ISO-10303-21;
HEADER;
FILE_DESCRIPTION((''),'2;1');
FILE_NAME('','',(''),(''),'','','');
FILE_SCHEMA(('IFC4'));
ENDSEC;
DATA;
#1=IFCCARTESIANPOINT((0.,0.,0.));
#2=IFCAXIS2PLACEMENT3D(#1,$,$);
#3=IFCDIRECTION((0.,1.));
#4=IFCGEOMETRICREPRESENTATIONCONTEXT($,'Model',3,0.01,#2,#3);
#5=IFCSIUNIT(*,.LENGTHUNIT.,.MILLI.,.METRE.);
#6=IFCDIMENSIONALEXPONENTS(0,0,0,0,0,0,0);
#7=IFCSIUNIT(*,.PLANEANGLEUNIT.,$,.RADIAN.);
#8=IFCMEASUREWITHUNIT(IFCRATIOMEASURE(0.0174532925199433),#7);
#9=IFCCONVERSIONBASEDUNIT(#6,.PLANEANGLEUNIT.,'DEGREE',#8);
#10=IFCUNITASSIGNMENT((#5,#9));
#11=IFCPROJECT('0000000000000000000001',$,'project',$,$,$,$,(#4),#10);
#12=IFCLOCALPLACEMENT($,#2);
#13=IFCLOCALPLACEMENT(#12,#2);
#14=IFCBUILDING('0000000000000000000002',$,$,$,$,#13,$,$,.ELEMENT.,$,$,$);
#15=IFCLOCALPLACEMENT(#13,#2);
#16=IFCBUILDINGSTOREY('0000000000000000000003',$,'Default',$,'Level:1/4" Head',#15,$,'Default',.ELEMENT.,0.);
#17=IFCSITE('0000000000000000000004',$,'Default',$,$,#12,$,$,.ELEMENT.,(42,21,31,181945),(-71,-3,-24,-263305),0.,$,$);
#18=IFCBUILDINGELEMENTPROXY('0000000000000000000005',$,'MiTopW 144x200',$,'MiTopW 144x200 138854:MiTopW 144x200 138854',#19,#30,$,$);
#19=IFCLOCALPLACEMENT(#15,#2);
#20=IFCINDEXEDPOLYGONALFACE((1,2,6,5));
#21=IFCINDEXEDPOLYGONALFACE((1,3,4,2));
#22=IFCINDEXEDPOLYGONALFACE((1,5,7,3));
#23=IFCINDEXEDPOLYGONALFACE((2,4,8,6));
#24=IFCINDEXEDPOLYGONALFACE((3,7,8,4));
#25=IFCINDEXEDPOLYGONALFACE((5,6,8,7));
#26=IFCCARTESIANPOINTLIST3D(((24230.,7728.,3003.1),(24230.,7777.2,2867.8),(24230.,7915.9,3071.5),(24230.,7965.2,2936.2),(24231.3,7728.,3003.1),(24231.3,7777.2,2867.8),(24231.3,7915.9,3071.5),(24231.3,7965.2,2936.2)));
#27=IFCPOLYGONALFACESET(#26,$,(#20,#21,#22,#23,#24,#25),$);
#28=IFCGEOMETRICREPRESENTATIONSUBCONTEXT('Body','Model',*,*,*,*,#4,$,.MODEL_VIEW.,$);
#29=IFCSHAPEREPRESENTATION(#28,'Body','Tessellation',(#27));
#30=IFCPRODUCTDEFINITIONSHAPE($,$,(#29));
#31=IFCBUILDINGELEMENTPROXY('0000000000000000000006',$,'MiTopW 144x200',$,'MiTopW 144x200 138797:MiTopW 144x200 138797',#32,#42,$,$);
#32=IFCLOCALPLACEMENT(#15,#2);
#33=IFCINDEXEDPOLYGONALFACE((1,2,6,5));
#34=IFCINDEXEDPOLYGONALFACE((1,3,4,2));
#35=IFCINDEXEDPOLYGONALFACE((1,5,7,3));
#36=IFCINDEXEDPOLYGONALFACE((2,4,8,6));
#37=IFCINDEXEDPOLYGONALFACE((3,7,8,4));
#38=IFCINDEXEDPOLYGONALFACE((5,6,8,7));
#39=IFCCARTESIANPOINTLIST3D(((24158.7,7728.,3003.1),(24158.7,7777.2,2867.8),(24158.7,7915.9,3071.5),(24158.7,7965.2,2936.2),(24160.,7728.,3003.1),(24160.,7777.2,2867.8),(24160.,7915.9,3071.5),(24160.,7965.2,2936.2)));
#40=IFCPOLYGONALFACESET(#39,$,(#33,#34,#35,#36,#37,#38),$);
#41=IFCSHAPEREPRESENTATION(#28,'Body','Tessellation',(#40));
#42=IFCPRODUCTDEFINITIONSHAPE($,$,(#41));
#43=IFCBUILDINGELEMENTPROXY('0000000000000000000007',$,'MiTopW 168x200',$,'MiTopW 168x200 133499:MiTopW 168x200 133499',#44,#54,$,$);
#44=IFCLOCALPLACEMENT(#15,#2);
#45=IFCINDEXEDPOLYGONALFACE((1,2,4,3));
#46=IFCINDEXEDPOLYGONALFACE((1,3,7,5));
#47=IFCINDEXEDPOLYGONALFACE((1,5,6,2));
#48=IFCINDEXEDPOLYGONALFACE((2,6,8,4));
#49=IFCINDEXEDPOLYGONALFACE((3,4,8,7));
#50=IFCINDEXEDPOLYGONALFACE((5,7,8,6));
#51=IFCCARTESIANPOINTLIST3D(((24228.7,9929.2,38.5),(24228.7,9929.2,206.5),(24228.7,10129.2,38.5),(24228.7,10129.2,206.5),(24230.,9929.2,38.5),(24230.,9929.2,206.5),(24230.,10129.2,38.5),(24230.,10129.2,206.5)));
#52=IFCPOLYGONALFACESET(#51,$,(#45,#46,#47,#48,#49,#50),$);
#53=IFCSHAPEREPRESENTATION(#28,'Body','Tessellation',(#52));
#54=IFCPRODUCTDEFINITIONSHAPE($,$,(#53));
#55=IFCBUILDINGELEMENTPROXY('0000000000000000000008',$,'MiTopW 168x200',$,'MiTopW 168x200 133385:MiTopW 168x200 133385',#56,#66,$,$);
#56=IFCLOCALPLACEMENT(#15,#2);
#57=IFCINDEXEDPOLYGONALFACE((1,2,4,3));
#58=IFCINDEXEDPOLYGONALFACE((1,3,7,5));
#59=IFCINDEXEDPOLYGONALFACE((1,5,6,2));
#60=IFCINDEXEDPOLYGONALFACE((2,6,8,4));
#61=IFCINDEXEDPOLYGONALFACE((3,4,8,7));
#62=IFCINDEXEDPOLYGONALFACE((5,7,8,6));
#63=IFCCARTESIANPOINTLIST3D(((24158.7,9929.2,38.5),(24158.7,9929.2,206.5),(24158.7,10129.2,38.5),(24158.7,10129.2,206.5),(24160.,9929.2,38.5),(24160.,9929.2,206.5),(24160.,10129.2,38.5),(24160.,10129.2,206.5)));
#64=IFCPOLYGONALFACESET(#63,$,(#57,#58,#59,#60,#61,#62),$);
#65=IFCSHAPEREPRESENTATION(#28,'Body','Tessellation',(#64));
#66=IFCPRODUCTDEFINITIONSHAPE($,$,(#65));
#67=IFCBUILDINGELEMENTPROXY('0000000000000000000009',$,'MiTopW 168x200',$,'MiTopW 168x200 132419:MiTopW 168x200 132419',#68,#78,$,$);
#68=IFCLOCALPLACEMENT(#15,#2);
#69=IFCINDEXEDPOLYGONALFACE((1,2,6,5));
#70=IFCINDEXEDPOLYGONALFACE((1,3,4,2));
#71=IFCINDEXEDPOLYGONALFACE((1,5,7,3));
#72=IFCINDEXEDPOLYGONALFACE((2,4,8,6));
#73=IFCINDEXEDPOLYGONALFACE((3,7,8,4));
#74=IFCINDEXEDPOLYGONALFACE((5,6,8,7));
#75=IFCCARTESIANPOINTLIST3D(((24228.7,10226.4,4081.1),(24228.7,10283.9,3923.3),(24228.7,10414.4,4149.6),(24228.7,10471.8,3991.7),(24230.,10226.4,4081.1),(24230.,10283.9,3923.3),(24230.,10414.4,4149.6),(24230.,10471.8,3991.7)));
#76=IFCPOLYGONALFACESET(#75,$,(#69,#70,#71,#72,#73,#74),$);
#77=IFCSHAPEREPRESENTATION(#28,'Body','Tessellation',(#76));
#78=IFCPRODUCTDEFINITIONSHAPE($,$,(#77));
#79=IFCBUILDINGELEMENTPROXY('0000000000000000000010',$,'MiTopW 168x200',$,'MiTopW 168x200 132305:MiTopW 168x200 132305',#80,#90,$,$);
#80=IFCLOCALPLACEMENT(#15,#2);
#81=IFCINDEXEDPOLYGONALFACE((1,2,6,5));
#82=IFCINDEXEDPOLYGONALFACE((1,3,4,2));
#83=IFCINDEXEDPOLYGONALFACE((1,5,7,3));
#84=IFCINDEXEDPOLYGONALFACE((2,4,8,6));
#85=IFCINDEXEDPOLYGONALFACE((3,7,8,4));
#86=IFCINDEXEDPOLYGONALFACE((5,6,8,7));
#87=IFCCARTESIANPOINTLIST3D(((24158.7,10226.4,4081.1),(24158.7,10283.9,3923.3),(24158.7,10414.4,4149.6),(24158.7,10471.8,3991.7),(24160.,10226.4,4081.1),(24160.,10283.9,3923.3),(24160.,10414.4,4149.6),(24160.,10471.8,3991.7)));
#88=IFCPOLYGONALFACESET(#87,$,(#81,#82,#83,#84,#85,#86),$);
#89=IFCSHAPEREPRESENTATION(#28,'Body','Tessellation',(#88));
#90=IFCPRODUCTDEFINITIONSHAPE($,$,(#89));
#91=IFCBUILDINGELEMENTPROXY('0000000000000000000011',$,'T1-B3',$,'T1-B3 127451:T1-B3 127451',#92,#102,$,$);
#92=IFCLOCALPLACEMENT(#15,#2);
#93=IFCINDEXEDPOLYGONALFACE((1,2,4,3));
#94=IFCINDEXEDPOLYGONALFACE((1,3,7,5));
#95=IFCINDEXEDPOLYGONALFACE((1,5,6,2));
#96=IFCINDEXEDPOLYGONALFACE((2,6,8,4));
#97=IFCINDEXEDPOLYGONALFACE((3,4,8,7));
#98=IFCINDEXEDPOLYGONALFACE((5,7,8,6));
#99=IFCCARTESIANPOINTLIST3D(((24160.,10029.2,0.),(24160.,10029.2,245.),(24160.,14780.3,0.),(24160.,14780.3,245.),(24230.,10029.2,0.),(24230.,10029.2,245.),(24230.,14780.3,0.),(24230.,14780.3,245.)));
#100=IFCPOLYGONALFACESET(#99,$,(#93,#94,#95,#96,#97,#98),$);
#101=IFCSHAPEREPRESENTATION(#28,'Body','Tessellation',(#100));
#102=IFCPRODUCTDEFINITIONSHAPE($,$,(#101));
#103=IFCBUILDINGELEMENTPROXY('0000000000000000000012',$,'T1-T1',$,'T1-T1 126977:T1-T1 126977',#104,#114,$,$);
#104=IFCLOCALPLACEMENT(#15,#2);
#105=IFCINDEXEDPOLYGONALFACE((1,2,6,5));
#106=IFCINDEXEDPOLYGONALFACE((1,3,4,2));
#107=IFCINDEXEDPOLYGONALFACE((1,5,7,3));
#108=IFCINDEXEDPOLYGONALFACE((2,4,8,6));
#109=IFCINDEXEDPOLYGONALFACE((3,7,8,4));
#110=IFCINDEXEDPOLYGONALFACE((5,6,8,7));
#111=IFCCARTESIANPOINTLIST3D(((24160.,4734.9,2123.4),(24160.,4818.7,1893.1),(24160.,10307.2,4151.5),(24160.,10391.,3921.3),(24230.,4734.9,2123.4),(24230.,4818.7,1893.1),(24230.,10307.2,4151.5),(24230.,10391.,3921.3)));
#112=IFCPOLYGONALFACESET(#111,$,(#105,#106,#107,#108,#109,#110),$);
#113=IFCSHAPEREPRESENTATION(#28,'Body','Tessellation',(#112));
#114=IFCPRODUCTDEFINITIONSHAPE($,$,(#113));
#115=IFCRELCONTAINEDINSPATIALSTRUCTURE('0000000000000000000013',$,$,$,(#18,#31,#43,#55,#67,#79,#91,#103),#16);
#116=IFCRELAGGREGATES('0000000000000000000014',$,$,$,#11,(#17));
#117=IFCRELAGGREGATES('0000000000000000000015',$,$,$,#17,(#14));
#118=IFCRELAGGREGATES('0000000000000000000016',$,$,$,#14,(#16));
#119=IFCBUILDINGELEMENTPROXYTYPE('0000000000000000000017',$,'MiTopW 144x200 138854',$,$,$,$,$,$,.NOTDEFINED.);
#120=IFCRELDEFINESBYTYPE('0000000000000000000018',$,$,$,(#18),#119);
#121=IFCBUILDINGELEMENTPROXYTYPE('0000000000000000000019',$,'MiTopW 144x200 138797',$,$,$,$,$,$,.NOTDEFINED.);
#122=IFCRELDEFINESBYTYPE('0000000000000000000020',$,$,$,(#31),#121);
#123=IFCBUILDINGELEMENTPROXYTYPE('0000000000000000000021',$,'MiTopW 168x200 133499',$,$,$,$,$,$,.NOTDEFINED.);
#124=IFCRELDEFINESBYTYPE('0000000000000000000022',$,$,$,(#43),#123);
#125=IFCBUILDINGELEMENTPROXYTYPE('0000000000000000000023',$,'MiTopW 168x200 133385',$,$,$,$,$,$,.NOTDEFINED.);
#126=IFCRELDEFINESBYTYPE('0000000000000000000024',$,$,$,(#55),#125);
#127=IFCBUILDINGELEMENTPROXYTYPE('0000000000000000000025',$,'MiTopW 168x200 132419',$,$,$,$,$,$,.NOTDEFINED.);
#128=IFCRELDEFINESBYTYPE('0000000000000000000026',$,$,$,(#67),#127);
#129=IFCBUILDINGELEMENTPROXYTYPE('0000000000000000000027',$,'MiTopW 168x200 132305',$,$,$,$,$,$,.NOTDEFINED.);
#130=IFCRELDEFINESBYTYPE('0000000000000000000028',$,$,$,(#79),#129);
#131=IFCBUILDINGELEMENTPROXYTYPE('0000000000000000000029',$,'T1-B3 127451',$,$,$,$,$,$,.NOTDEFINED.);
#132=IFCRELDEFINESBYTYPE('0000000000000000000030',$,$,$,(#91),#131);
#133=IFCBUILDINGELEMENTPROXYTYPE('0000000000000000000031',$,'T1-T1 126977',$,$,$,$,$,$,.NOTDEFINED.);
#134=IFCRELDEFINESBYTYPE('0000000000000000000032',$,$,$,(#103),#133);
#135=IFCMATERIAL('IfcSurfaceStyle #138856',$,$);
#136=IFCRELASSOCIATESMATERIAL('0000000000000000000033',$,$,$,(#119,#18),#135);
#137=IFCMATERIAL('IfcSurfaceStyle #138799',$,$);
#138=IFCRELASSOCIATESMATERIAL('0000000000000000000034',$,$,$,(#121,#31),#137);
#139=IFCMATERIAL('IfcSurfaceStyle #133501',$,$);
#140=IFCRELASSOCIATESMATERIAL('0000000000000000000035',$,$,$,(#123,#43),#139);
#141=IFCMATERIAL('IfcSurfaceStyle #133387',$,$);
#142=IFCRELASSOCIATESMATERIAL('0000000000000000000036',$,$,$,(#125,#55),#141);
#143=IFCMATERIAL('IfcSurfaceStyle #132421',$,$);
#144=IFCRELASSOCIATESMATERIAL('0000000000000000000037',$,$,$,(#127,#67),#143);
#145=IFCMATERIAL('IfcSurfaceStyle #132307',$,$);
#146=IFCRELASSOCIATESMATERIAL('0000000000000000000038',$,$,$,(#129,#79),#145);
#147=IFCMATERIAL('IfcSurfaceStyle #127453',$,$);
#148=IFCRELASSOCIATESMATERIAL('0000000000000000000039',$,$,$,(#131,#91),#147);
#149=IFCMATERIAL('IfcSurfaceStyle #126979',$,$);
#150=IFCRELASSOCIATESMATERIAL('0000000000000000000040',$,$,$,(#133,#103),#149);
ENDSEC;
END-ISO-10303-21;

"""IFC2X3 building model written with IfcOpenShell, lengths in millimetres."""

from ifc_helpers import new_model, entity, si_unit, converted_unit, direction, frame, origin, origin_2d_with_axis, place, context, subcontext, project, spatial, polyline, rectangle, outline, extrude, source, transform, mapped, material, type_object, type_shapes, element, save


model = new_model("IFC2X3")

# Units and contexts
model_context = context("Model", 3, precision=0.01, world=origin(), true_north=direction((0.0, 1.0)))
body_context = subcontext(model_context, "Body", "Model", "MODEL_VIEW")
ifc_project = project(units=[si_unit("LENGTHUNIT", "METRE", prefix="MILLI"), converted_unit("PLANEANGLEUNIT", "DEGREE", entity("IfcRatioMeasure", 0.0174532925199433), si_unit("PLANEANGLEUNIT", "RADIAN"), dimensions=[0, 0, 0, 0, 0, 0, 0])], contexts=[model_context])

# Site, building, storey
site_placement = place(None, origin())
site = spatial("IfcSite", under=ifc_project, at=site_placement, Name="Default", CompositionType="ELEMENT", RefLatitude=(42, 21, 31, 181945), RefLongitude=(-71, -3, -24, -263305), RefElevation=0.0)
building_placement = place(site_placement, origin())
building = spatial("IfcBuilding", under=site, at=building_placement, CompositionType="ELEMENT")
storey_placement = place(building_placement, origin())
storey = spatial("IfcBuildingStorey", under=building, at=storey_placement, Name="Default", ObjectType="Level:1/4\" Head", LongName="Default", CompositionType="ELEMENT", Elevation=0.0)

# Building element proxies
ifc_material_1 = material(Name="IfcSurfaceStyle #138856")
building_element_proxy_type_1 = type_object("IfcBuildingElementProxyType", Name="MiTopW 144x200 138854", PredefinedType="NOTDEFINED", material=ifc_material_1)
shared_shape_1 = source(origin(), body_context, "Body", "SweptSolid", [
    extrude(outline(polyline([(-100.0, -72.0), (100.0, -72.0), (100.0, 72.0), (-100.0, 72.0), (-100.0, -72.0)])), frame((100.0, 72.0, 0.0), z_axis=(0.0, 0.0, 1.0), x_axis=(-1.0, 0.0, 0.0)), (0.0, 0.0, 1.0), 1.3),
])
type_shapes(building_element_proxy_type_1, [shared_shape_1])
proxy_1_placement = place(building_placement, frame((24231.3, 7965.2, 2936.2), z_axis=(-1.0, 0.0, 0.0), x_axis=(0.0, -0.939693, -0.34202)))
element("IfcBuildingElementProxy", 1, at=proxy_1_placement, inside=storey, type_object=building_element_proxy_type_1, material=ifc_material_1, Name="MiTopW 144x200", ObjectType="MiTopW 144x200 138854:MiTopW 144x200 138854", context=body_context, shape_type="MappedRepresentation", body=[
    mapped(shared_shape_1, transform((0.0, 0.0, 0.0), scale=1.0)),
])
ifc_material_2 = material(Name="IfcSurfaceStyle #138799")
building_element_proxy_type_2 = type_object("IfcBuildingElementProxyType", Name="MiTopW 144x200 138797", PredefinedType="NOTDEFINED", material=ifc_material_2)
shared_shape_2 = source(origin(), body_context, "Body", "SweptSolid", [
    extrude(outline(polyline([(-100.0, -72.0), (100.0, -72.0), (100.0, 72.0), (-100.0, 72.0), (-100.0, -72.0)])), frame((100.0, 72.0, 0.0), z_axis=(0.0, 0.0, 1.0), x_axis=(-1.0, 0.0, 0.0)), (0.0, 0.0, 1.0), 1.3),
])
type_shapes(building_element_proxy_type_2, [shared_shape_2])
proxy_2_placement = place(building_placement, frame((24160.0, 7965.2, 2936.2), z_axis=(-1.0, 0.0, 0.0), x_axis=(0.0, -0.939693, -0.34202)))
element("IfcBuildingElementProxy", 2, at=proxy_2_placement, inside=storey, type_object=building_element_proxy_type_2, material=ifc_material_2, Name="MiTopW 144x200", ObjectType="MiTopW 144x200 138797:MiTopW 144x200 138797", context=body_context, shape_type="MappedRepresentation", body=[
    mapped(shared_shape_2, transform((0.0, 0.0, 0.0), scale=1.0)),
])
ifc_material_3 = material(Name="IfcSurfaceStyle #133501")
building_element_proxy_type_3 = type_object("IfcBuildingElementProxyType", Name="MiTopW 168x200 133499", PredefinedType="NOTDEFINED", material=ifc_material_3)
shared_shape_3 = source(origin(), body_context, "Body", "SweptSolid", [
    extrude(rectangle(XDim=200.0, YDim=168.0, at=origin_2d_with_axis()), frame((100.0, 84.0, 0.0), z_axis=(0.0, 0.0, 1.0), x_axis=(-1.0, 0.0, 0.0)), (0.0, 0.0, 1.0), 1.3),
])
type_shapes(building_element_proxy_type_3, [shared_shape_3])
proxy_3_placement = place(building_placement, frame((24230.0, 9929.2, 206.5), z_axis=(-1.0, 0.0, 0.0), x_axis=(0.0, 1.0, 0.0)))
element("IfcBuildingElementProxy", 3, at=proxy_3_placement, inside=storey, type_object=building_element_proxy_type_3, material=ifc_material_3, Name="MiTopW 168x200", ObjectType="MiTopW 168x200 133499:MiTopW 168x200 133499", context=body_context, shape_type="MappedRepresentation", body=[
    mapped(shared_shape_3, transform((0.0, 0.0, 0.0), scale=1.0)),
])
ifc_material_4 = material(Name="IfcSurfaceStyle #133387")
building_element_proxy_type_4 = type_object("IfcBuildingElementProxyType", Name="MiTopW 168x200 133385", PredefinedType="NOTDEFINED", material=ifc_material_4)
shared_shape_4 = source(origin(), body_context, "Body", "SweptSolid", [
    extrude(rectangle(XDim=200.0, YDim=168.0, at=origin_2d_with_axis()), frame((100.0, 84.0, 0.0), z_axis=(0.0, 0.0, 1.0), x_axis=(-1.0, 0.0, 0.0)), (0.0, 0.0, 1.0), 1.3),
])
type_shapes(building_element_proxy_type_4, [shared_shape_4])
proxy_4_placement = place(building_placement, frame((24160.0, 9929.2, 206.5), z_axis=(-1.0, 0.0, 0.0), x_axis=(0.0, 1.0, 0.0)))
element("IfcBuildingElementProxy", 4, at=proxy_4_placement, inside=storey, type_object=building_element_proxy_type_4, material=ifc_material_4, Name="MiTopW 168x200", ObjectType="MiTopW 168x200 133385:MiTopW 168x200 133385", context=body_context, shape_type="MappedRepresentation", body=[
    mapped(shared_shape_4, transform((0.0, 0.0, 0.0), scale=1.0)),
])
ifc_material_5 = material(Name="IfcSurfaceStyle #132421")
building_element_proxy_type_5 = type_object("IfcBuildingElementProxyType", Name="MiTopW 168x200 132419", PredefinedType="NOTDEFINED", material=ifc_material_5)
shared_shape_5 = source(origin(), body_context, "Body", "SweptSolid", [
    extrude(outline(polyline([(-100.0, -84.0), (100.0, -84.0), (100.0, 84.0), (-100.0, 84.0), (-100.0, -84.0)])), frame((100.0, 84.0, 0.0), z_axis=(0.0, 0.0, 1.0), x_axis=(-1.0, 0.0, 0.0)), (0.0, 0.0, 1.0), 1.3),
])
type_shapes(building_element_proxy_type_5, [shared_shape_5])
proxy_5_placement = place(building_placement, frame((24230.0, 10226.4, 4081.1), z_axis=(-1.0, 0.0, 0.0), x_axis=(0.0, 0.939693, 0.34202)))
element("IfcBuildingElementProxy", 5, at=proxy_5_placement, inside=storey, type_object=building_element_proxy_type_5, material=ifc_material_5, Name="MiTopW 168x200", ObjectType="MiTopW 168x200 132419:MiTopW 168x200 132419", context=body_context, shape_type="MappedRepresentation", body=[
    mapped(shared_shape_5, transform((0.0, 0.0, 0.0), scale=1.0)),
])
ifc_material_6 = material(Name="IfcSurfaceStyle #132307")
building_element_proxy_type_6 = type_object("IfcBuildingElementProxyType", Name="MiTopW 168x200 132305", PredefinedType="NOTDEFINED", material=ifc_material_6)
shared_shape_6 = source(origin(), body_context, "Body", "SweptSolid", [
    extrude(outline(polyline([(-100.0, -84.0), (100.0, -84.0), (100.0, 84.0), (-100.0, 84.0), (-100.0, -84.0)])), frame((100.0, 84.0, 0.0), z_axis=(0.0, 0.0, 1.0), x_axis=(-1.0, 0.0, 0.0)), (0.0, 0.0, 1.0), 1.3),
])
type_shapes(building_element_proxy_type_6, [shared_shape_6])
proxy_6_placement = place(building_placement, frame((24160.0, 10226.4, 4081.1), z_axis=(-1.0, 0.0, 0.0), x_axis=(0.0, 0.939693, 0.34202)))
element("IfcBuildingElementProxy", 6, at=proxy_6_placement, inside=storey, type_object=building_element_proxy_type_6, material=ifc_material_6, Name="MiTopW 168x200", ObjectType="MiTopW 168x200 132305:MiTopW 168x200 132305", context=body_context, shape_type="MappedRepresentation", body=[
    mapped(shared_shape_6, transform((0.0, 0.0, 0.0), scale=1.0)),
])
ifc_material_7 = material(Name="IfcSurfaceStyle #127453")
building_element_proxy_type_7 = type_object("IfcBuildingElementProxyType", Name="T1-B3 127451", PredefinedType="NOTDEFINED", material=ifc_material_7)
shared_shape_7 = source(origin(), body_context, "Body", "SweptSolid", [
    extrude(rectangle(XDim=4751.0, YDim=245.0, at=origin_2d_with_axis()), frame((2375.5, 122.5, 0.0), z_axis=(0.0, 0.0, 1.0), x_axis=(-1.0, 0.0, 0.0)), (0.0, 0.0, 1.0), 70.0),
])
type_shapes(building_element_proxy_type_7, [shared_shape_7])
proxy_7_placement = place(building_placement, frame((24230.0, 10029.2, 245.0), z_axis=(-1.0, 0.0, 0.0), x_axis=(0.0, 1.0, 0.0)))
element("IfcBuildingElementProxy", 7, at=proxy_7_placement, inside=storey, type_object=building_element_proxy_type_7, material=ifc_material_7, Name="T1-B3", ObjectType="T1-B3 127451:T1-B3 127451", context=body_context, shape_type="MappedRepresentation", body=[
    mapped(shared_shape_7, transform((0.0, 0.0, 0.0), scale=1.0)),
])
ifc_material_8 = material(Name="IfcSurfaceStyle #126979")
building_element_proxy_type_8 = type_object("IfcBuildingElementProxyType", Name="T1-T1 126977", PredefinedType="NOTDEFINED", material=ifc_material_8)
shared_shape_8 = source(origin(), body_context, "Body", "SweptSolid", [
    extrude(outline(polyline([(-2965.0, -122.5), (2965.0, -122.5), (2965.0, 122.5), (-2965.0, 122.5), (-2965.0, -122.5)])), frame((2965.0, 122.5, 0.0), z_axis=(0.0, 0.0, 1.0), x_axis=(-1.0, 0.0, 0.0)), (0.0, 0.0, 1.0), 70.0),
])
type_shapes(building_element_proxy_type_8, [shared_shape_8])
proxy_8_placement = place(building_placement, frame((24230.0, 10391.0, 3921.3), z_axis=(-1.0, 0.0, 0.0), x_axis=(0.0, -0.939693, -0.34202)))
element("IfcBuildingElementProxy", 8, at=proxy_8_placement, inside=storey, type_object=building_element_proxy_type_8, material=ifc_material_8, Name="T1-T1", ObjectType="T1-T1 126977:T1-T1 126977", context=body_context, shape_type="MappedRepresentation", body=[
    mapped(shared_shape_8, transform((0.0, 0.0, 0.0), scale=1.0)),
])

save(model, "model.ifc")
